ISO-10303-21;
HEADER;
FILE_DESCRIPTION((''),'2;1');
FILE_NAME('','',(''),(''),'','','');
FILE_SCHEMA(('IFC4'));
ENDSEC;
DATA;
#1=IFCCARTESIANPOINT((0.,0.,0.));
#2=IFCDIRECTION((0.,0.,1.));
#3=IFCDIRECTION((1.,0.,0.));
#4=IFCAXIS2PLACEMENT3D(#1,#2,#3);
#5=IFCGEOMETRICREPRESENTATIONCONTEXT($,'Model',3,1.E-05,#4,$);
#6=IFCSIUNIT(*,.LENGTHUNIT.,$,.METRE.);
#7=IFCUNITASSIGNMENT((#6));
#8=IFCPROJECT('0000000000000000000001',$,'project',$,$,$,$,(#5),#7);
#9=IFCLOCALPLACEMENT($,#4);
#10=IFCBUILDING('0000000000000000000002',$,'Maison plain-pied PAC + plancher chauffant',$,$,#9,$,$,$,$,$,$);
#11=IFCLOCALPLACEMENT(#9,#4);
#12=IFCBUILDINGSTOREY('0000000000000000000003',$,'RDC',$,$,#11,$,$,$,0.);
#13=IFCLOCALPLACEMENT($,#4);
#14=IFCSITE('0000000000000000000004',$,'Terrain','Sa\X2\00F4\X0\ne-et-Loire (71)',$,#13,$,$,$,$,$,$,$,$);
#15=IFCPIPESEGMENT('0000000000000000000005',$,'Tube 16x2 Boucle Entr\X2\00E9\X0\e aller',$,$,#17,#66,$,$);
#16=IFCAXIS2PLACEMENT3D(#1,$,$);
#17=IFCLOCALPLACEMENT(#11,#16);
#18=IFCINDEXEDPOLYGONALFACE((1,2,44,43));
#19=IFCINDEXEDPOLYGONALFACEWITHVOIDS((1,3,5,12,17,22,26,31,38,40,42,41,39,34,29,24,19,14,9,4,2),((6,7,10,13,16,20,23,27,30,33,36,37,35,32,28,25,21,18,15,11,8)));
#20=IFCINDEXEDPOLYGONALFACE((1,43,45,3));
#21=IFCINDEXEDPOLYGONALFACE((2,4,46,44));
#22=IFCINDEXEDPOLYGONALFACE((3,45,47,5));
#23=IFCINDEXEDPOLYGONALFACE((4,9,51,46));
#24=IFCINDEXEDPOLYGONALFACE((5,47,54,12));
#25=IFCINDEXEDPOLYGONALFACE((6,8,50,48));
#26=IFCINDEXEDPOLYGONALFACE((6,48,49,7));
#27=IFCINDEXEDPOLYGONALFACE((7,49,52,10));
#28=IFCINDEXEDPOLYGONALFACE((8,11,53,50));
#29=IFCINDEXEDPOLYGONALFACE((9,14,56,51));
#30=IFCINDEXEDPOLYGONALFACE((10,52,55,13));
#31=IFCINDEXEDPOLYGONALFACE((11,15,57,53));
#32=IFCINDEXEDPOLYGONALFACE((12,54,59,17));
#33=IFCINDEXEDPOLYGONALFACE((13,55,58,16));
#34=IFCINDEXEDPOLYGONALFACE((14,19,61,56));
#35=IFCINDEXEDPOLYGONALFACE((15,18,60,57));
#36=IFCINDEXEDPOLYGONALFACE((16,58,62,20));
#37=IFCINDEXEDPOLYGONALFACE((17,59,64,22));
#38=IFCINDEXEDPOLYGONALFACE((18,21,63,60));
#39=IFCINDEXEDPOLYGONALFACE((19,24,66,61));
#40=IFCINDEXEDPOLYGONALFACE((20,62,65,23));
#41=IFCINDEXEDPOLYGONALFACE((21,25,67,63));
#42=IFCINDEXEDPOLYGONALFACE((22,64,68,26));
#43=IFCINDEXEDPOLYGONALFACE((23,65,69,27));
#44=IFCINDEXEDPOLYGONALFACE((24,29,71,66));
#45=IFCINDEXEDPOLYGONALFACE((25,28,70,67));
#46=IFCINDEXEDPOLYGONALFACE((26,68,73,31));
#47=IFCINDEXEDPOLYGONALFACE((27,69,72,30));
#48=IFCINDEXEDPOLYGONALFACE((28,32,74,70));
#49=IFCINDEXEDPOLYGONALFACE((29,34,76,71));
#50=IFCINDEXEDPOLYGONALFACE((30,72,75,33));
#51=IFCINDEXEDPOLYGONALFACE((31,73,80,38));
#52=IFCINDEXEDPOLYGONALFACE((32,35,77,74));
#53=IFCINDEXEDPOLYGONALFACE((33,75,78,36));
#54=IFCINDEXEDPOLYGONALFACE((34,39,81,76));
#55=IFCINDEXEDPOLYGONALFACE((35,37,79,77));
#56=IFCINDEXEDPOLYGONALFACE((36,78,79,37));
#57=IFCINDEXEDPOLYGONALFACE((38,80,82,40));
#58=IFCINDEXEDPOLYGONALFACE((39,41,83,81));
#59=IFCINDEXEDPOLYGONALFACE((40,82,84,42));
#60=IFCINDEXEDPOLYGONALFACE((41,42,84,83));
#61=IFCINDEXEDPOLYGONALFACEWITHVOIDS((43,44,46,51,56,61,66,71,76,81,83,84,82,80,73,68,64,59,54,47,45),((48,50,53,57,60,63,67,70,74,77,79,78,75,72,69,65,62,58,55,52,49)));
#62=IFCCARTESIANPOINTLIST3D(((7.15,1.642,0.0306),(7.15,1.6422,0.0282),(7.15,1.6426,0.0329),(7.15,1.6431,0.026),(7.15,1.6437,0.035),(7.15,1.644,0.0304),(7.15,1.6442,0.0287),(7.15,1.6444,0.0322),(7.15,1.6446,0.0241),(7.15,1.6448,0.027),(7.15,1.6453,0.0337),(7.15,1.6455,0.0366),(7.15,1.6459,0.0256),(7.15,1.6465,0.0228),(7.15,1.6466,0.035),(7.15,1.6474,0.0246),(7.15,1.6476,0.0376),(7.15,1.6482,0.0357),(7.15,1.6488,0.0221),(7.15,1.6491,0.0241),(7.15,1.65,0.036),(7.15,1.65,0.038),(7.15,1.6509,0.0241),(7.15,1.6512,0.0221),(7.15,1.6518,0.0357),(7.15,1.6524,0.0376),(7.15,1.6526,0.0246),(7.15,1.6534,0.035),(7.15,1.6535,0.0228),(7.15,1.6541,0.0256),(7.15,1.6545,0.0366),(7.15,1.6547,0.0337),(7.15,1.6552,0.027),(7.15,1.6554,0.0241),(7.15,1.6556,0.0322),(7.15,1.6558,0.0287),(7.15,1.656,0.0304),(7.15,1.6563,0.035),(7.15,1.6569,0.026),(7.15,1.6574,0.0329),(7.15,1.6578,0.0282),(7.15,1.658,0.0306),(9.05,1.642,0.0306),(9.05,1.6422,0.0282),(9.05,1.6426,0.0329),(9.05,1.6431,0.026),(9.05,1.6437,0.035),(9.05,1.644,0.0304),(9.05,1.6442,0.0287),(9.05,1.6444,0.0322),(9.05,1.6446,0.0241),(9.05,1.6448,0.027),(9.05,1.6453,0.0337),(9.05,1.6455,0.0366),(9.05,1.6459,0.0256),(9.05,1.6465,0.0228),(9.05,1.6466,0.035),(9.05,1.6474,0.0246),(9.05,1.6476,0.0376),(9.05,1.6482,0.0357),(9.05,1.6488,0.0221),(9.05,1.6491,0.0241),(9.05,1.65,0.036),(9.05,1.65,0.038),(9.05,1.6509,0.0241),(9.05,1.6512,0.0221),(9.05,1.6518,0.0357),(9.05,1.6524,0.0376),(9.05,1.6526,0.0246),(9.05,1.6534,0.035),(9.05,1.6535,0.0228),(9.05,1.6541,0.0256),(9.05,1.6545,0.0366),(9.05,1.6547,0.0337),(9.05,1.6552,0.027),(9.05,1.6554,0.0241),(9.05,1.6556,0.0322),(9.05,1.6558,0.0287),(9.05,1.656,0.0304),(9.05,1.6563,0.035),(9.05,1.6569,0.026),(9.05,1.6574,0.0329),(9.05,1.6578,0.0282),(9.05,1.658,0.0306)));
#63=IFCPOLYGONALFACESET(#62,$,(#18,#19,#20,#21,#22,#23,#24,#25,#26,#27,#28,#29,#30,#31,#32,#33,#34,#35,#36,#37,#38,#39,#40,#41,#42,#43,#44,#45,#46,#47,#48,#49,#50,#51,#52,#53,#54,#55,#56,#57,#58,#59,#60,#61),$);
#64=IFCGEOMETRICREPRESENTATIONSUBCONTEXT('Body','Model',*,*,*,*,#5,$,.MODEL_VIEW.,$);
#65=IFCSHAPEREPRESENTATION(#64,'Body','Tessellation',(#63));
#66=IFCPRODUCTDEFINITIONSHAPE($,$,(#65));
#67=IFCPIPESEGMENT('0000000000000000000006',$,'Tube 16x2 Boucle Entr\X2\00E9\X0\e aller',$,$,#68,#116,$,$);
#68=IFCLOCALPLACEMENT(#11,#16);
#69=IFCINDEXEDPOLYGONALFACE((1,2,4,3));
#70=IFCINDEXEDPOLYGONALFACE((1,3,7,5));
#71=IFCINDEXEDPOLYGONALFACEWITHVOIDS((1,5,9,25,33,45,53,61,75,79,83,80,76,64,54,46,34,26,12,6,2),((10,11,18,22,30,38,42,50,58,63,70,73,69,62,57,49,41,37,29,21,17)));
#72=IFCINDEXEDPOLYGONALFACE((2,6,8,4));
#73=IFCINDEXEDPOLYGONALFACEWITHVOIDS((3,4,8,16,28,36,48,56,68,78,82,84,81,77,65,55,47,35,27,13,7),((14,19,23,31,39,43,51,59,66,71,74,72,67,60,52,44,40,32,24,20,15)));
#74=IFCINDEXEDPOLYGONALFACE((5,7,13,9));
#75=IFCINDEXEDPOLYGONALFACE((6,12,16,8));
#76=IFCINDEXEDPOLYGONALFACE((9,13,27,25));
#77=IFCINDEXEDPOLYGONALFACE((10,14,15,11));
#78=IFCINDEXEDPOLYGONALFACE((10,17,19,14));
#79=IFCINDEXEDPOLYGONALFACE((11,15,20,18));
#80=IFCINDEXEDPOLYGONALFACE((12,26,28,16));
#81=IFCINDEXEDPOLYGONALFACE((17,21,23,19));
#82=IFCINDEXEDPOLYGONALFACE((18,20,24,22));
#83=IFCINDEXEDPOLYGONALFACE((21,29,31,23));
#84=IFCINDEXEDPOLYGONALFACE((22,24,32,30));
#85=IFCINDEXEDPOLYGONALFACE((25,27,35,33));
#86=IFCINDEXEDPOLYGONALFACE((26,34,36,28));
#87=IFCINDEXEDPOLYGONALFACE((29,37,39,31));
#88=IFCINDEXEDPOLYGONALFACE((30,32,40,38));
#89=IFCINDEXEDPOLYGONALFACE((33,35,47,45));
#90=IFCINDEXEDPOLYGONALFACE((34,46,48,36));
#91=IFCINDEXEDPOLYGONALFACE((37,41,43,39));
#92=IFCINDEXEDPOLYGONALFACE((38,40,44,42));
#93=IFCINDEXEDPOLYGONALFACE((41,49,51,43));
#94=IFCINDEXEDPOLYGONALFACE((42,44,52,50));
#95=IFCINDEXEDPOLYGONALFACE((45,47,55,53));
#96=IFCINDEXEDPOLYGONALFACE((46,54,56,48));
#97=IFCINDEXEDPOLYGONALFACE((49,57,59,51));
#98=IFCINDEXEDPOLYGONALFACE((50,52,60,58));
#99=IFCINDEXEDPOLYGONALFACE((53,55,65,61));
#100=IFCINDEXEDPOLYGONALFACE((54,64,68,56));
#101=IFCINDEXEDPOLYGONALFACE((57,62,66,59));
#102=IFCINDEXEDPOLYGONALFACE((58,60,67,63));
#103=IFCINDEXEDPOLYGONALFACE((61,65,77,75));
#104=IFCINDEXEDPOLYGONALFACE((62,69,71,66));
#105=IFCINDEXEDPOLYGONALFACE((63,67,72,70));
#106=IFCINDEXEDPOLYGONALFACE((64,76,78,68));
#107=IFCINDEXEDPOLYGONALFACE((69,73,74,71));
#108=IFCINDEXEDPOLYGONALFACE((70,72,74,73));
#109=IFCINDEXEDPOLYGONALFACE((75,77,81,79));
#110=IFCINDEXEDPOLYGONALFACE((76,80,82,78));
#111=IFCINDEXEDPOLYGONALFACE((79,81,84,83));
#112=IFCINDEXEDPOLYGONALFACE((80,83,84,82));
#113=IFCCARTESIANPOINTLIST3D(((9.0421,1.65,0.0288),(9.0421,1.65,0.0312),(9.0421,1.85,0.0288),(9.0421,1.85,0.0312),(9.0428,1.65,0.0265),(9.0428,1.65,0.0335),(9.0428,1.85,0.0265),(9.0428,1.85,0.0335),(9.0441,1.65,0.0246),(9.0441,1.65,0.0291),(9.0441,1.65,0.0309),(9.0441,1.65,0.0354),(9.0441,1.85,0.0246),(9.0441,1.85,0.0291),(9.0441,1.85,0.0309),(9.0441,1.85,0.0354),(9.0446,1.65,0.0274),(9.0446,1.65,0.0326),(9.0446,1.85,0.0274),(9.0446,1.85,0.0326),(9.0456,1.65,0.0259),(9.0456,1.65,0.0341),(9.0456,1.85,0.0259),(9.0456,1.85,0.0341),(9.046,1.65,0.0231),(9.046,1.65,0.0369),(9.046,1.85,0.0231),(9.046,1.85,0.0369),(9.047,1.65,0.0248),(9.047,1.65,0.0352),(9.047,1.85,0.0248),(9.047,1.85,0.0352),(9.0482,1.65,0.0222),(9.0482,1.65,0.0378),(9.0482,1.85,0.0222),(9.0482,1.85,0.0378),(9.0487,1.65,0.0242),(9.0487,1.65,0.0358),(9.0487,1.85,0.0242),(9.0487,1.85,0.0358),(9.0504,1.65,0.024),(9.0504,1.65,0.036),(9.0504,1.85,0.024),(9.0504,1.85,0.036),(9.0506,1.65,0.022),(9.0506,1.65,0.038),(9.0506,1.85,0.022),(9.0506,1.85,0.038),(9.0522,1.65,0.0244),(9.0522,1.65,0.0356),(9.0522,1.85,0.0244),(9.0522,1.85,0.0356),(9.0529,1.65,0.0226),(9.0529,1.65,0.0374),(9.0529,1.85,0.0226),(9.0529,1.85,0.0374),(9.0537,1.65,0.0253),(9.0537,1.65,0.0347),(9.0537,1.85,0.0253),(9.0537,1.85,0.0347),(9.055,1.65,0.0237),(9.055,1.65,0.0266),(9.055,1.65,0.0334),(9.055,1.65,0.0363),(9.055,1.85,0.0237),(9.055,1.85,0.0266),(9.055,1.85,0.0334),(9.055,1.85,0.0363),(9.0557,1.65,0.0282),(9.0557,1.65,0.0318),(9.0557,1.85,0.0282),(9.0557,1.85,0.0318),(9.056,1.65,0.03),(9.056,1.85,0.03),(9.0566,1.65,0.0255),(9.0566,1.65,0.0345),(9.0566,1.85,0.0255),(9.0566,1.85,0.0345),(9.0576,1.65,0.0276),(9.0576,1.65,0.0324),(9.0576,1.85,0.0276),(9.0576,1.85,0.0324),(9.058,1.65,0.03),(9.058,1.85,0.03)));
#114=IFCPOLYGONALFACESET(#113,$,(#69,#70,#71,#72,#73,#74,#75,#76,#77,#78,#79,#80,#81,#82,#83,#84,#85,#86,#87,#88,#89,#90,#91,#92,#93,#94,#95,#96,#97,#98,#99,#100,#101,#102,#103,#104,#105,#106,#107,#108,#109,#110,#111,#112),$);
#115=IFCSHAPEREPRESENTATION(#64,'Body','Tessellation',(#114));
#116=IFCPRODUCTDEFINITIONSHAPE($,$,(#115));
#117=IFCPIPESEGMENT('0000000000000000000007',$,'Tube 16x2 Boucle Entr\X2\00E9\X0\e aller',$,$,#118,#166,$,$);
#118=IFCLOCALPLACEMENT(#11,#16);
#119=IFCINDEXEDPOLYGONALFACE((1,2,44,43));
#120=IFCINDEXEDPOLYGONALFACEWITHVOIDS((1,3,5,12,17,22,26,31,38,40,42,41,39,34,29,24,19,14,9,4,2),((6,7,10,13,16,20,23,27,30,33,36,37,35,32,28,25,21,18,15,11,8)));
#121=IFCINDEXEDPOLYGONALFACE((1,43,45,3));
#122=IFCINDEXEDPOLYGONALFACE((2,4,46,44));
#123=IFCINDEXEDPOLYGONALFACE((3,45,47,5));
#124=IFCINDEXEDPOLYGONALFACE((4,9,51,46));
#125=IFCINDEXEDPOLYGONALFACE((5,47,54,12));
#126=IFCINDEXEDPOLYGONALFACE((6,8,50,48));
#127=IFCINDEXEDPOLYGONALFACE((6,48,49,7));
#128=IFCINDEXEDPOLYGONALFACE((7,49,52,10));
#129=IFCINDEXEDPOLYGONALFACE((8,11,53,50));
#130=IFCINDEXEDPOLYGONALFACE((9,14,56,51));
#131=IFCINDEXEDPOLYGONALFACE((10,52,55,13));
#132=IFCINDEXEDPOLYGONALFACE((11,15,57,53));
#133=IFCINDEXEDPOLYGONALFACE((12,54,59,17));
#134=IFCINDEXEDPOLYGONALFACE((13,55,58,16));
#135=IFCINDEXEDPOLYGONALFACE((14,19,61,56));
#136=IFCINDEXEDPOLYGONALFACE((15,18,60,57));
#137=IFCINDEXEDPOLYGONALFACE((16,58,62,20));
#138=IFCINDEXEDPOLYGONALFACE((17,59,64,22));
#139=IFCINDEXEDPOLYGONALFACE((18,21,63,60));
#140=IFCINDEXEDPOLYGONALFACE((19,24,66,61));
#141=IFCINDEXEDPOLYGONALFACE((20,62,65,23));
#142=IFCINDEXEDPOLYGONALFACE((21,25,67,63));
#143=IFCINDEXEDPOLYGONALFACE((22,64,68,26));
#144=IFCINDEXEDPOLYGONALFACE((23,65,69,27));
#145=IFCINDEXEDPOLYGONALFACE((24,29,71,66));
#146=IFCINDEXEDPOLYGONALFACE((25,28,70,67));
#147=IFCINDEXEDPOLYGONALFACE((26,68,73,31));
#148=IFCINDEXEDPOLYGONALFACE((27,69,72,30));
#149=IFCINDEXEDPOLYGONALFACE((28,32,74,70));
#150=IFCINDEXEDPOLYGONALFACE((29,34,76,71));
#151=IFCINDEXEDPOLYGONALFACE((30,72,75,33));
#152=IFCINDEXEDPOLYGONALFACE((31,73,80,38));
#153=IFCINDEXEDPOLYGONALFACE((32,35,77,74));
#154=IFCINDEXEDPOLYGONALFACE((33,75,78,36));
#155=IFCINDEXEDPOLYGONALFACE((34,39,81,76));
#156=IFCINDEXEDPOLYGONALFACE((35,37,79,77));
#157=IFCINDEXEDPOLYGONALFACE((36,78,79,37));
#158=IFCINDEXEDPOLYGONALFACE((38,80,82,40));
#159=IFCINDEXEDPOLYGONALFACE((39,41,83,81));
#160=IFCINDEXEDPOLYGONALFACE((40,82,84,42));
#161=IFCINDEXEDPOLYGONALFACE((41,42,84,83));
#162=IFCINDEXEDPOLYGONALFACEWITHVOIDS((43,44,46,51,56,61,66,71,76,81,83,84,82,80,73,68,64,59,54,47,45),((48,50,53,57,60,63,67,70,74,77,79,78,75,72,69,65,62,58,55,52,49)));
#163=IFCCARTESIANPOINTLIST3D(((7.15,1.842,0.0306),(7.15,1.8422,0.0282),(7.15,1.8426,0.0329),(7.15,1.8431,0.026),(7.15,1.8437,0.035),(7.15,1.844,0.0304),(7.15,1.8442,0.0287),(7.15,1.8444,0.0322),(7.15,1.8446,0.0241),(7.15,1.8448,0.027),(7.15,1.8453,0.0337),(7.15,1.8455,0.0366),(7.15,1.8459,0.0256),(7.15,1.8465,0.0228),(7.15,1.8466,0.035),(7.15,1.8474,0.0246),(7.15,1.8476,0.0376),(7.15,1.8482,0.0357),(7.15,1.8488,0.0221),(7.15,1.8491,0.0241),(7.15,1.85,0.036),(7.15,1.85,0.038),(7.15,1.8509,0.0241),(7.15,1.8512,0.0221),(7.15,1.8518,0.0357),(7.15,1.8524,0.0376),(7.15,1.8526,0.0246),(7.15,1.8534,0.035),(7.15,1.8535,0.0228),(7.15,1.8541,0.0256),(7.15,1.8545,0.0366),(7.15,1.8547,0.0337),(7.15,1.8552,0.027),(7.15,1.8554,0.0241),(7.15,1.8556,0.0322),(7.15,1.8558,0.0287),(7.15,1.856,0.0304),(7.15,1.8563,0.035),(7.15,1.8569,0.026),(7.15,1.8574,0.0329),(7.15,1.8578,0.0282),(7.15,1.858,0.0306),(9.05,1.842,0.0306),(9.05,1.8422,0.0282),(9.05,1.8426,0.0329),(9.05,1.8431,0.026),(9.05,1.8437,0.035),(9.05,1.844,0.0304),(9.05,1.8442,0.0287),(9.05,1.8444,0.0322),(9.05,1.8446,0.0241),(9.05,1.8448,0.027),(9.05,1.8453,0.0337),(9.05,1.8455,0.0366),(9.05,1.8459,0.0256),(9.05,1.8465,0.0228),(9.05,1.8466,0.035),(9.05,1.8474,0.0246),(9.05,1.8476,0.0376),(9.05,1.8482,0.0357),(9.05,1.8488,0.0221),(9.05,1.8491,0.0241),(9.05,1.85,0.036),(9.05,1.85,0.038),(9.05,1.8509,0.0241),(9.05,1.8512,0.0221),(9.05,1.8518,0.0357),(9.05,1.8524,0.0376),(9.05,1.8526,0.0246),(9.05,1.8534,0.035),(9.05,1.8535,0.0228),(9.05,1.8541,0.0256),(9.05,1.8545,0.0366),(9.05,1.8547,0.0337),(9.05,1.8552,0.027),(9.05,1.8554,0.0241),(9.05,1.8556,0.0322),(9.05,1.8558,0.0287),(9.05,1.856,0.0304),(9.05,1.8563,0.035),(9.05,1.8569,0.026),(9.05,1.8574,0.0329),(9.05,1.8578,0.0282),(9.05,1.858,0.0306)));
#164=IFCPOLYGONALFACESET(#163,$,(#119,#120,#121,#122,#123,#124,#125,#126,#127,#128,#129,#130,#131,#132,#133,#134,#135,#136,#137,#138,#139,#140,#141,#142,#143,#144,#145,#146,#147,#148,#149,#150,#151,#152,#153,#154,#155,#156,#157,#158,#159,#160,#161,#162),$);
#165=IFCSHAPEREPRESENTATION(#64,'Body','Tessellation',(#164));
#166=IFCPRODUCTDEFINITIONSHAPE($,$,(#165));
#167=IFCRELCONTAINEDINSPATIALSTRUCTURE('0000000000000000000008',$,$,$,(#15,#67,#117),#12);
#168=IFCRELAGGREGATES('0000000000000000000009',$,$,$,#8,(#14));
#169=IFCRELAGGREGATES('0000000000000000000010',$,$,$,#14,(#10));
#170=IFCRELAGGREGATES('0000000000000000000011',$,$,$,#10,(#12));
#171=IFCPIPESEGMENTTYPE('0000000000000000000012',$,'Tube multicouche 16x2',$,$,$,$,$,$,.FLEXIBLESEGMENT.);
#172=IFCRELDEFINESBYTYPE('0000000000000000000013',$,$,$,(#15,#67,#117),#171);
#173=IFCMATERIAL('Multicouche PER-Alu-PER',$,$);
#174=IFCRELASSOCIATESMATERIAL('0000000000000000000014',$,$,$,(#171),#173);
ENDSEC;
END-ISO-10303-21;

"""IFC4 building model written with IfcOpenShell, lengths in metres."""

from ifc_helpers import new_model, si_unit, frame, origin_with_axes, place, context, subcontext, project, spatial, hollow_circle, extrude, material, type_object, element, save


model = new_model("IFC4")

# Units and contexts
model_context = context("Model", 3, precision=1e-05, world=origin_with_axes())
body_context = subcontext(model_context, "Body", "Model", "MODEL_VIEW")
ifc_project = project(units=[si_unit("LENGTHUNIT", "METRE")], contexts=[model_context])

# Site, building, storey
site_placement = place(None, origin_with_axes())
site = spatial("IfcSite", under=ifc_project, at=site_placement, Name="Terrain", Description="Saône-et-Loire (71)")
building_placement = place(None, origin_with_axes())
building = spatial("IfcBuilding", under=site, at=building_placement, Name="Maison plain-pied PAC + plancher chauffant")
storey_placement = place(building_placement, origin_with_axes())
storey = spatial("IfcBuildingStorey", under=building, at=storey_placement, Name="RDC", Elevation=0.0)

# Pipe segments
ifc_material_1 = material(Name="Multicouche PER-Alu-PER")
pipe_segment_type = type_object("IfcPipeSegmentType", Name="Tube multicouche 16x2", PredefinedType="FLEXIBLESEGMENT", material=ifc_material_1)
pipe_segment_1_placement = place(storey_placement, frame((7.15, 1.65, 0.03), z_axis=(1.0, 0.0, 0.0), x_axis=(0.0, 0.0, 1.0)))
element("IfcPipeSegment", 1, at=pipe_segment_1_placement, inside=storey, type_object=pipe_segment_type, Name="Tube 16x2 Boucle Entrée aller", context=body_context, shape_type="SweptSolid", body=[
    extrude(hollow_circle(Radius=0.008, WallThickness=0.002), origin_with_axes(), (0.0, 0.0, 1.0), 1.9),
])
pipe_segment_2_placement = place(storey_placement, frame((9.05, 1.65, 0.03), z_axis=(0.0, 1.0, 0.0), x_axis=(1.0, 0.0, 0.0)))
element("IfcPipeSegment", 2, at=pipe_segment_2_placement, inside=storey, type_object=pipe_segment_type, Name="Tube 16x2 Boucle Entrée aller", context=body_context, shape_type="SweptSolid", body=[
    extrude(hollow_circle(Radius=0.008, WallThickness=0.002), origin_with_axes(), (0.0, 0.0, 1.0), 0.2),
])
pipe_segment_3_placement = place(storey_placement, frame((9.05, 1.85, 0.03), z_axis=(-1.0, 0.0, 0.0), x_axis=(0.0, 0.0, 1.0)))
element("IfcPipeSegment", 3, at=pipe_segment_3_placement, inside=storey, type_object=pipe_segment_type, Name="Tube 16x2 Boucle Entrée aller", context=body_context, shape_type="SweptSolid", body=[
    extrude(hollow_circle(Radius=0.008, WallThickness=0.002), origin_with_axes(), (0.0, 0.0, 1.0), 1.9),
])

save(model, "model.ifc")
